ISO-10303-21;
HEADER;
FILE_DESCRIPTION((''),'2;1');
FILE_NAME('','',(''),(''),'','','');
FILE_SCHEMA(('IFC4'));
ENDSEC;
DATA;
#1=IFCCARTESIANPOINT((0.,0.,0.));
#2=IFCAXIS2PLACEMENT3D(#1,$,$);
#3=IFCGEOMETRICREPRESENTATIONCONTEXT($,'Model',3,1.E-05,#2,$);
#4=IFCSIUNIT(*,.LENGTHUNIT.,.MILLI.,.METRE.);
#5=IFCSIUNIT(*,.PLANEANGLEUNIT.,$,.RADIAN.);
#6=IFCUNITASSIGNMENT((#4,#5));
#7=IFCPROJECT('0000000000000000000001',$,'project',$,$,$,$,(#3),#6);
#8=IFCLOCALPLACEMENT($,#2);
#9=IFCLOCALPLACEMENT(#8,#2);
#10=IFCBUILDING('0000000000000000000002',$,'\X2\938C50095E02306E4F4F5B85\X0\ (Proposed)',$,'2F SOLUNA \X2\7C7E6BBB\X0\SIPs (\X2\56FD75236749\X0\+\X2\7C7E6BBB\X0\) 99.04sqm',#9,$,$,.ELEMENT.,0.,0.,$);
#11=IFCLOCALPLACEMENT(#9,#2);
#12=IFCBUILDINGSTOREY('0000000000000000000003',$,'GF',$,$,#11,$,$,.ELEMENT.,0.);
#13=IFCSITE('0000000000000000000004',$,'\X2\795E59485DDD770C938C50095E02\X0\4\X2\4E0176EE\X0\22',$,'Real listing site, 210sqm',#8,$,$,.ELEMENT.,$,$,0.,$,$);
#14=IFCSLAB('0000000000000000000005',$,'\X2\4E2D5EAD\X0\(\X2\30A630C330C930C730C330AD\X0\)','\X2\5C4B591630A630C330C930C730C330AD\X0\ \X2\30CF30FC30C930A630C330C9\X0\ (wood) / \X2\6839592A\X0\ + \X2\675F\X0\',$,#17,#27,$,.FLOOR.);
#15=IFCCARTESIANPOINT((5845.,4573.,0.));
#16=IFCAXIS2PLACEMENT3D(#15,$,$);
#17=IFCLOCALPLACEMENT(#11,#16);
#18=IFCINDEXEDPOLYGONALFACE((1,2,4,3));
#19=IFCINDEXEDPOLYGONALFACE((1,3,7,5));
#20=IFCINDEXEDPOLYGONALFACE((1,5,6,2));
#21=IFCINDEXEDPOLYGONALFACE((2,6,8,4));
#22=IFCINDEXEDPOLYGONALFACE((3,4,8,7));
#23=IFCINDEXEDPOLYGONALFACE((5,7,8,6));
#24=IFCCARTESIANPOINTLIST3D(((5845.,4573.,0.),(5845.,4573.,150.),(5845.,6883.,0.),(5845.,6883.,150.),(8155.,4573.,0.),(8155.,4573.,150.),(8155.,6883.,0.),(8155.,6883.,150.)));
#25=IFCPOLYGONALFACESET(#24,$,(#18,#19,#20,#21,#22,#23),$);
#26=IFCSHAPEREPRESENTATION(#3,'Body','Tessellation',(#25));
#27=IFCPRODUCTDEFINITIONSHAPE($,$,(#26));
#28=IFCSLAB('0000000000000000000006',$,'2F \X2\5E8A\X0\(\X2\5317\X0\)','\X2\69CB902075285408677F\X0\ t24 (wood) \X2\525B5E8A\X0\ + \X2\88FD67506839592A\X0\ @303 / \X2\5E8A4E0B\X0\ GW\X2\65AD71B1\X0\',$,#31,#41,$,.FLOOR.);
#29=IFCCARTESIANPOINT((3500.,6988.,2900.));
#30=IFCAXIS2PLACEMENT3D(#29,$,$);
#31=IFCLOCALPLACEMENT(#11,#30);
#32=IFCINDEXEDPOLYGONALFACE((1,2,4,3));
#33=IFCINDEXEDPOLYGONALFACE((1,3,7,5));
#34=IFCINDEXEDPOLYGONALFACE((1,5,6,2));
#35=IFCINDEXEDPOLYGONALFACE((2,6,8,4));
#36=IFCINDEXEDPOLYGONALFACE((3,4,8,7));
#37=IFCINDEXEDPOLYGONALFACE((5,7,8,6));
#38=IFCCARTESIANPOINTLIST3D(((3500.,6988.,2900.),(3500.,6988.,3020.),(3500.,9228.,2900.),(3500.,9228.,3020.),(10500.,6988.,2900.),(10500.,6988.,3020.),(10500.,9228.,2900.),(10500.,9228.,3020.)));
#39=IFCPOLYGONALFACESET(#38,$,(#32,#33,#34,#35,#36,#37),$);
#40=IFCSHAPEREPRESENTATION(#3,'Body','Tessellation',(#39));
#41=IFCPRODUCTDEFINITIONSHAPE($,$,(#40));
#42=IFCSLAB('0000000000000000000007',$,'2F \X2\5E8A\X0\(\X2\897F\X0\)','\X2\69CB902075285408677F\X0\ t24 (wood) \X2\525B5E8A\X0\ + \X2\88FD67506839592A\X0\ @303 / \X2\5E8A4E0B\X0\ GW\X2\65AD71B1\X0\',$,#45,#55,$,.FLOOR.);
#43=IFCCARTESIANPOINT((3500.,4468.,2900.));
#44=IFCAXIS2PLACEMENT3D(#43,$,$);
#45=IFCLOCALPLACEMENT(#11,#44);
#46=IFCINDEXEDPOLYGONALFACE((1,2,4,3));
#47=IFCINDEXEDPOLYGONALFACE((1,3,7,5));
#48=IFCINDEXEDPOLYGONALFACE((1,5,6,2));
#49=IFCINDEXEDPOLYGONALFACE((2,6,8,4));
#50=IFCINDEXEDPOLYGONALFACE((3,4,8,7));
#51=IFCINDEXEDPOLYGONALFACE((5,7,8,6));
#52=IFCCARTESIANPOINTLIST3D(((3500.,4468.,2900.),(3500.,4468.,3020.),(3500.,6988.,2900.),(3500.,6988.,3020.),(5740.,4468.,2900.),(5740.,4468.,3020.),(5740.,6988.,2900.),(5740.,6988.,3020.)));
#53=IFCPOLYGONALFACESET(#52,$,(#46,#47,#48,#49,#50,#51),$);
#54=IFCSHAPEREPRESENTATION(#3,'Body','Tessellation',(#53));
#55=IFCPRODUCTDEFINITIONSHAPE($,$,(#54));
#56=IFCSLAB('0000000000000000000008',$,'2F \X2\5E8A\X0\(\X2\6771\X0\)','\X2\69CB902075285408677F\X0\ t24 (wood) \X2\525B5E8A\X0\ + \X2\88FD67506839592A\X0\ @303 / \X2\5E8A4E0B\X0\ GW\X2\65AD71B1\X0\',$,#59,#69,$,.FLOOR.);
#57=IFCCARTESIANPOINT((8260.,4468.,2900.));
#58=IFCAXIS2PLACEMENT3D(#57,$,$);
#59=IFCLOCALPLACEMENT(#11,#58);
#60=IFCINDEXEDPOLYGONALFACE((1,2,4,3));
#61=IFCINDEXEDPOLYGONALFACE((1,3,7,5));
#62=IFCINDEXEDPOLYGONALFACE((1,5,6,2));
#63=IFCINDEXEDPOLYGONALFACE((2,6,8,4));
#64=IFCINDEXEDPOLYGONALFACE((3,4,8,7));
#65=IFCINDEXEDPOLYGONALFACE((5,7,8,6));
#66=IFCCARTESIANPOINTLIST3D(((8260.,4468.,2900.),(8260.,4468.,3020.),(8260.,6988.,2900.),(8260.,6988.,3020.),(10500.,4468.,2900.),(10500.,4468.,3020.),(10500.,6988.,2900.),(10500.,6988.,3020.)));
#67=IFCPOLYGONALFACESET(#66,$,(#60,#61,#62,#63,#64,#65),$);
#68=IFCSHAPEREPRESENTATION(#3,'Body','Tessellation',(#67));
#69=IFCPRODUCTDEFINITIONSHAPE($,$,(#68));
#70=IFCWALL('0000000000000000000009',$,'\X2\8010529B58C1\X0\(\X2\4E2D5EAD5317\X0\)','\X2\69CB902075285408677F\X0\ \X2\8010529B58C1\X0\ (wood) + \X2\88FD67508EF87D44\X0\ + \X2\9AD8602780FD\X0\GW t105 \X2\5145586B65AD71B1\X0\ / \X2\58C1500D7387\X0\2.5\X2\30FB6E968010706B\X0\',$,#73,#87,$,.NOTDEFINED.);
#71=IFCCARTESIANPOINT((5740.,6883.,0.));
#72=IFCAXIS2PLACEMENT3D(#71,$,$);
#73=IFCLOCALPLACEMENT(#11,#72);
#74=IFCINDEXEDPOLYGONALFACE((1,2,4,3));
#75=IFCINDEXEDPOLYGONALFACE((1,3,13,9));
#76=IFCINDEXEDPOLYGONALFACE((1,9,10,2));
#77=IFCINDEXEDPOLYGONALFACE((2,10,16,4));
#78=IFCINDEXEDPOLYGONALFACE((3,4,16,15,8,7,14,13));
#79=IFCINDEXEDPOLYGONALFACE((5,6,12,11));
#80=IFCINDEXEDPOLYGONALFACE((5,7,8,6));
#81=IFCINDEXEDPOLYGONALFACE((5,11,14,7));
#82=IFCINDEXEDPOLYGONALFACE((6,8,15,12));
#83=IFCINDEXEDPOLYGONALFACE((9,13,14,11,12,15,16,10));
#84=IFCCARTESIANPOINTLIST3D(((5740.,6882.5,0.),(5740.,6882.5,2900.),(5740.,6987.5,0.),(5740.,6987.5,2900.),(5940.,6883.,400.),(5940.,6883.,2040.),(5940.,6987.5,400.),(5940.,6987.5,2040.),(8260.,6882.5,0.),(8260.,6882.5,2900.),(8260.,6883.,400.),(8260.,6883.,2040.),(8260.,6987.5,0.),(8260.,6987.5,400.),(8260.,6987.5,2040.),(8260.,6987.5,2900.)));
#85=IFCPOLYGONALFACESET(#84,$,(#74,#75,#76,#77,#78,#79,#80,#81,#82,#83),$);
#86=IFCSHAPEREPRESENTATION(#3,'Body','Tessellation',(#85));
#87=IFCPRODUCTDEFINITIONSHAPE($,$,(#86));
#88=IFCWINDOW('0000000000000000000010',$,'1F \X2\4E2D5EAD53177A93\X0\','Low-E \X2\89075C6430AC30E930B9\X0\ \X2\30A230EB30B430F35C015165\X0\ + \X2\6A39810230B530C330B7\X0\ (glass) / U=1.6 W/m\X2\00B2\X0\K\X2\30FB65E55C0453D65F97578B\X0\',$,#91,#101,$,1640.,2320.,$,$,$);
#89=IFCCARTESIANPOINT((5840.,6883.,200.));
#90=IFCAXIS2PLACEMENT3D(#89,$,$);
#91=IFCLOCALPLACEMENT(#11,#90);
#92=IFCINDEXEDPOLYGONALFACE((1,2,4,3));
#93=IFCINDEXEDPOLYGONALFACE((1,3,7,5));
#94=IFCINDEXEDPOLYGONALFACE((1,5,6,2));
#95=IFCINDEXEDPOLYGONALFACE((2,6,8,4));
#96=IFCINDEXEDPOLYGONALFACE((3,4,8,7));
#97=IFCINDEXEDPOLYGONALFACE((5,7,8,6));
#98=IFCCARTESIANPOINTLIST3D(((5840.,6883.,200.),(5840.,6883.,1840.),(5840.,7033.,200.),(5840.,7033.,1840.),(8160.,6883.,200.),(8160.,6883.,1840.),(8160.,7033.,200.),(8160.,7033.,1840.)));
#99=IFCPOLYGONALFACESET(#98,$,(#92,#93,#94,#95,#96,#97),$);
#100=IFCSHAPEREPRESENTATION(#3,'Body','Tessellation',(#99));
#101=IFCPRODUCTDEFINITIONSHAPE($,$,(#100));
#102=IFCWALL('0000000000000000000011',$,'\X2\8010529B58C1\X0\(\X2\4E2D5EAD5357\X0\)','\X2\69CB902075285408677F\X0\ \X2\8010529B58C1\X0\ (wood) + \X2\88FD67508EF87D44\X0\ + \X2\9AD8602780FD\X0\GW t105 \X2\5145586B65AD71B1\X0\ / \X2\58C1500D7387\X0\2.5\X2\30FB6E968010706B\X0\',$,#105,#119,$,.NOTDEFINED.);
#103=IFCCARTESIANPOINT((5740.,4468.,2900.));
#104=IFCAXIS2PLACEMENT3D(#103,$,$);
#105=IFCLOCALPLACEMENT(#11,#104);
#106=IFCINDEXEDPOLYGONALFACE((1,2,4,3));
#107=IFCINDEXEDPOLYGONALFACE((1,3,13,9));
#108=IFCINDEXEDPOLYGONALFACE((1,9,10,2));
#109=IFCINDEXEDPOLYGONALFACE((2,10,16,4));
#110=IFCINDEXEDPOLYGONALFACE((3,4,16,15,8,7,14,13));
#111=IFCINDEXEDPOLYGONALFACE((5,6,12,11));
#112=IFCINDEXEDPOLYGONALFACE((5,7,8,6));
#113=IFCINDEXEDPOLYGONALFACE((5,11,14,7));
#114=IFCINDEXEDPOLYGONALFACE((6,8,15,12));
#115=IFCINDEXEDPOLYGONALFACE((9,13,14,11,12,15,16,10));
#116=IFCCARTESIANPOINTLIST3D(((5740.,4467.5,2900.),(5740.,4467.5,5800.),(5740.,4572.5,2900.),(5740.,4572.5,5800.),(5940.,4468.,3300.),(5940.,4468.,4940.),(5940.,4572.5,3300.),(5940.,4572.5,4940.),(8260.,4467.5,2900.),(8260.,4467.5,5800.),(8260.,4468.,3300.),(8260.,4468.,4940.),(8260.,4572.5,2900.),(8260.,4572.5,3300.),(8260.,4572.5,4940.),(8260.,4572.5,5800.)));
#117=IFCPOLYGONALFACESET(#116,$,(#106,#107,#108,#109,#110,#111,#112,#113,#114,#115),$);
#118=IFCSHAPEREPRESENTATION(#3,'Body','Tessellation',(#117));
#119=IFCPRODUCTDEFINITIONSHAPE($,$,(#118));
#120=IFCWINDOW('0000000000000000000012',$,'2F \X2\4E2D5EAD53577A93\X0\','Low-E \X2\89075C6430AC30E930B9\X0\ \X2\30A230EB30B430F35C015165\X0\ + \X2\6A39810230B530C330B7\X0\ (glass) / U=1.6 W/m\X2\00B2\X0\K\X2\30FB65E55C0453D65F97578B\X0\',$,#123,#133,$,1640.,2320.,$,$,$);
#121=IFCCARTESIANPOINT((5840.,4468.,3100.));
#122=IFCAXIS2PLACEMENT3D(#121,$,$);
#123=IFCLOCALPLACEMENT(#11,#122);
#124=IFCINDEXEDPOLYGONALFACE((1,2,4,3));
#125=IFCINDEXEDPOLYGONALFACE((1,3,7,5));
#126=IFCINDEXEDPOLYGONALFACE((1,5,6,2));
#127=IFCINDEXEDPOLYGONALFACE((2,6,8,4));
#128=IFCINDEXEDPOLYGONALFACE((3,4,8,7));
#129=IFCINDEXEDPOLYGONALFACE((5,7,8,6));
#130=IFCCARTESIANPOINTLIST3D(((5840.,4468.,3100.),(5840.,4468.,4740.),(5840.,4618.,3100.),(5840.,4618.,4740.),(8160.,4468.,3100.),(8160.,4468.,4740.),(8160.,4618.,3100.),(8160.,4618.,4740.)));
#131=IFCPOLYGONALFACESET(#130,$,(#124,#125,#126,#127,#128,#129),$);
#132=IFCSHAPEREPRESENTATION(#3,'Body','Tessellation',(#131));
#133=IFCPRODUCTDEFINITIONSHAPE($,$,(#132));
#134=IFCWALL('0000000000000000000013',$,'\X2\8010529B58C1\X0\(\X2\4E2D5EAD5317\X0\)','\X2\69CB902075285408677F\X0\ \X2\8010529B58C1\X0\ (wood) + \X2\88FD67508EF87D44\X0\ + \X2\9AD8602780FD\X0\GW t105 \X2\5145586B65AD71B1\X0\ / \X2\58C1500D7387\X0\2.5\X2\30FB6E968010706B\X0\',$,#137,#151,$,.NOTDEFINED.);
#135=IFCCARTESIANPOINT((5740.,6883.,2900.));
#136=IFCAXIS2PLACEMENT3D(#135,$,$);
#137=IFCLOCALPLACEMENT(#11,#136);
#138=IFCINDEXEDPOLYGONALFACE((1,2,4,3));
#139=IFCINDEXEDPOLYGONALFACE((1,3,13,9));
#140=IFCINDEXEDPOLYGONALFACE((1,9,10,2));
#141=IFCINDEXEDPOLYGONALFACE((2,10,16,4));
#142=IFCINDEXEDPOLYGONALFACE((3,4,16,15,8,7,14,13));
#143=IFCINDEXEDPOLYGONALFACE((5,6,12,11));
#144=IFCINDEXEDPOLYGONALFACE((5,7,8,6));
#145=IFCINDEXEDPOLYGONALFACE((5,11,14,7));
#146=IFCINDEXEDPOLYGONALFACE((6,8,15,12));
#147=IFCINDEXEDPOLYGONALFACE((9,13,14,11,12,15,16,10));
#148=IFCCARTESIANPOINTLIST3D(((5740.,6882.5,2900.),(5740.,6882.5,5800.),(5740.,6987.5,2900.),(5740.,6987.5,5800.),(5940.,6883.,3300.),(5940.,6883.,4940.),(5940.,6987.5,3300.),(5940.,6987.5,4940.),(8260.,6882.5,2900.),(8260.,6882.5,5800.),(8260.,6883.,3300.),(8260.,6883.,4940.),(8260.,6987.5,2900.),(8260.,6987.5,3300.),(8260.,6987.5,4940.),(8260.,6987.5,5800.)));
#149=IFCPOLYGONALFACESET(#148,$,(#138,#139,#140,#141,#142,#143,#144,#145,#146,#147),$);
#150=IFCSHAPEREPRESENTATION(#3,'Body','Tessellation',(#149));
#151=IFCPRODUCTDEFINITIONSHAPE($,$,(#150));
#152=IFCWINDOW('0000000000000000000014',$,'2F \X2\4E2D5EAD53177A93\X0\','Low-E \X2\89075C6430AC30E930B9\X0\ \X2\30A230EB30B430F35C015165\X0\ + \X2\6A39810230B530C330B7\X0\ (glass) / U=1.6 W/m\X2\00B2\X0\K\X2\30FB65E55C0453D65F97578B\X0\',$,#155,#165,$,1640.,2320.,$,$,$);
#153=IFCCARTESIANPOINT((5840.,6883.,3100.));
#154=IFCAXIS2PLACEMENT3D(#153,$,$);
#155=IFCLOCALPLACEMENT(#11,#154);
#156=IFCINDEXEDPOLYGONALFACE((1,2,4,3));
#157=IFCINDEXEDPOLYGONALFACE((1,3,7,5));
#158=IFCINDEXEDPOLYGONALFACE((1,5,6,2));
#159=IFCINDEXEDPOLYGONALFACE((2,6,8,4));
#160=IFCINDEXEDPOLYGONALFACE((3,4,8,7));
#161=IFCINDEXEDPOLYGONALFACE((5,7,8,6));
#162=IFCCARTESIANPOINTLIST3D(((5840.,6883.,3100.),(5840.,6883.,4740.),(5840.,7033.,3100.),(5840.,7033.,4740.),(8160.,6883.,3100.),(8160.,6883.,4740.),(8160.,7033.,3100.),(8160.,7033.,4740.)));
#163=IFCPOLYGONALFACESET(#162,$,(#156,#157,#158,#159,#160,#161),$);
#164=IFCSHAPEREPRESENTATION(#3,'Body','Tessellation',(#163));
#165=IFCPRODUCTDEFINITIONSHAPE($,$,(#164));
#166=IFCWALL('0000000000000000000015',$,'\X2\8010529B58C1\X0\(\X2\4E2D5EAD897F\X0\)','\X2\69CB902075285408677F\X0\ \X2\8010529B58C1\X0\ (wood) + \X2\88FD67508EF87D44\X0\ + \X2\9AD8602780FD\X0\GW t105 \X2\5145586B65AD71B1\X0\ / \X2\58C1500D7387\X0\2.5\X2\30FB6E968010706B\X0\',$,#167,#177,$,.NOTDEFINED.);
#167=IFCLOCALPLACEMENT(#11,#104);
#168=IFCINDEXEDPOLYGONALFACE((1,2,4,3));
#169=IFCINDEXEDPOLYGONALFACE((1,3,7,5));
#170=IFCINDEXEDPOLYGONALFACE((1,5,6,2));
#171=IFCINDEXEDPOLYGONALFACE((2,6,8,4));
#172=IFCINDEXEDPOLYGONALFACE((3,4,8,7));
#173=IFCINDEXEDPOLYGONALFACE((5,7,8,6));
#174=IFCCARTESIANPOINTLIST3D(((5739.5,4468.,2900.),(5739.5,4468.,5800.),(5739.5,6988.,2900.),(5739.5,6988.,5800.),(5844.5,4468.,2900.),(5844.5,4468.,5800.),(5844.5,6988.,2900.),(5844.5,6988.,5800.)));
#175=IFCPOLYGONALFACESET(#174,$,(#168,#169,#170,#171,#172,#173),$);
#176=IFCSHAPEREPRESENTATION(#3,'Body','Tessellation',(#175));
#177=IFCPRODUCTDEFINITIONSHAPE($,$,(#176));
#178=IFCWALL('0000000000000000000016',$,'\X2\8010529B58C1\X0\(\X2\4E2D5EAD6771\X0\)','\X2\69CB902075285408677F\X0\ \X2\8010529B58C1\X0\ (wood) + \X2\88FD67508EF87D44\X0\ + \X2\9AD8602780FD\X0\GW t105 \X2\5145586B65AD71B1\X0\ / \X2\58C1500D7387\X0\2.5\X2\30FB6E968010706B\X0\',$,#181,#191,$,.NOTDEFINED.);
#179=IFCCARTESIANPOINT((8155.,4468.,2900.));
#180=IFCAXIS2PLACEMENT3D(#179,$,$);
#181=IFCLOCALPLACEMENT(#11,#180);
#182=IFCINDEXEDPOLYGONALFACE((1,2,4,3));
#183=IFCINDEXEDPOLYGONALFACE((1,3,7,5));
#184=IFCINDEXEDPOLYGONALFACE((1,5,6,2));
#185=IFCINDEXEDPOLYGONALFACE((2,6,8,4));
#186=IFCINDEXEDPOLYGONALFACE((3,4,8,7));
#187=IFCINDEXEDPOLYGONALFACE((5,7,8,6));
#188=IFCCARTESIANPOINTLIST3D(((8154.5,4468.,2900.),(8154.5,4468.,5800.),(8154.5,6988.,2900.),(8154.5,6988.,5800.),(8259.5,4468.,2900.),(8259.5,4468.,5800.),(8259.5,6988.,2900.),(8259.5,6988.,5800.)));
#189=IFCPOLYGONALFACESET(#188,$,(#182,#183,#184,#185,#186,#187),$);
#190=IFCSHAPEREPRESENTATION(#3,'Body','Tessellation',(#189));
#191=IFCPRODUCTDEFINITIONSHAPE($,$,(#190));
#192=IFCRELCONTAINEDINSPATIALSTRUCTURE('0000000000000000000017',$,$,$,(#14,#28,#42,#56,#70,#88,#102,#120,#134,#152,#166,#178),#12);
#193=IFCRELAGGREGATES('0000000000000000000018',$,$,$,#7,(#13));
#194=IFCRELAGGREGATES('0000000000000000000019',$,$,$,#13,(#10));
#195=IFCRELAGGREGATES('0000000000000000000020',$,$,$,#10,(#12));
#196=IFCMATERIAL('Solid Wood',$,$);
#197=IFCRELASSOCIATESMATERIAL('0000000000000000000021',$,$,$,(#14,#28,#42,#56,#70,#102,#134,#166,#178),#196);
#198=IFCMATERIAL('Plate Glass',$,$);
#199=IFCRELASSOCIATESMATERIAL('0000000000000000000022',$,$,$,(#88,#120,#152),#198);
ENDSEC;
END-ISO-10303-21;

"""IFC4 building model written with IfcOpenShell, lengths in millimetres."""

from ifc_helpers import new_model, si_unit, frame, frame_2d, origin, place, context, project, spatial, rectangle, extrude, material, element, fill, save


model = new_model("IFC4")

# Units and contexts
model_context = context("Model", 3, precision=1e-05, world=origin())
ifc_project = project(units=[si_unit("LENGTHUNIT", "METRE", prefix="MILLI"), si_unit("PLANEANGLEUNIT", "RADIAN")], contexts=[model_context])

# Site, building, storey
site_placement = place(None, origin())
site = spatial("IfcSite", under=ifc_project, at=site_placement, Name="神奈川県鎌倉市4丁目22", ObjectType="Real listing site, 210sqm", CompositionType="ELEMENT", RefElevation=0.0)
building_placement = place(site_placement, origin())
building = spatial("IfcBuilding", under=site, at=building_placement, Name="鎌倉市の住宅 (Proposed)", ObjectType="2F SOLUNA 籾殻SIPs (国産杉+籾殻) 99.04sqm", CompositionType="ELEMENT", ElevationOfRefHeight=0.0, ElevationOfTerrain=0.0)
storey_placement = place(building_placement, origin())
storey = spatial("IfcBuildingStorey", under=building, at=storey_placement, Name="GF", CompositionType="ELEMENT", Elevation=0.0)

# Slabs
ifc_material_1 = material(Name="Solid Wood")
slab_1_placement = place(storey_placement, frame((5845.0, 4573.0, 0.0)))
element("IfcSlab", 1, at=slab_1_placement, inside=storey, material=ifc_material_1, Name="中庭(ウッドデッキ)", Description="屋外ウッドデッキ ハードウッド (wood) / 根太 + 束", PredefinedType="FLOOR", context=model_context, shape_type="SweptSolid", body=[
    extrude(rectangle(XDim=2310.0, YDim=2310.0, at=frame_2d((1155.0, 1155.0))), frame((5845.0, 4573.0, 0.0)), (0.0, 0.0, 1.0), 150.0),
])
slab_2_placement = place(storey_placement, frame((3500.0, 6988.0, 2900.0)))
element("IfcSlab", 2, at=slab_2_placement, inside=storey, material=ifc_material_1, Name="2F 床(北)", Description="構造用合板 t24 (wood) 剛床 + 製材根太 @303 / 床下 GW断熱", PredefinedType="FLOOR", context=model_context, shape_type="SweptSolid", body=[
    extrude(rectangle(XDim=7000.0, YDim=2240.0, at=frame_2d((3500.0, 1120.0))), frame((3500.0, 6988.0, 2900.0)), (0.0, 0.0, 1.0), 120.0),
])
slab_3_placement = place(storey_placement, frame((3500.0, 4468.0, 2900.0)))
element("IfcSlab", 3, at=slab_3_placement, inside=storey, material=ifc_material_1, Name="2F 床(西)", Description="構造用合板 t24 (wood) 剛床 + 製材根太 @303 / 床下 GW断熱", PredefinedType="FLOOR", context=model_context, shape_type="SweptSolid", body=[
    extrude(rectangle(XDim=2240.0, YDim=2520.0, at=frame_2d((1120.0, 1260.0))), frame((3500.0, 4468.0, 2900.0)), (0.0, 0.0, 1.0), 120.0),
])
slab_4_placement = place(storey_placement, frame((8260.0, 4468.0, 2900.0)))
element("IfcSlab", 4, at=slab_4_placement, inside=storey, material=ifc_material_1, Name="2F 床(東)", Description="構造用合板 t24 (wood) 剛床 + 製材根太 @303 / 床下 GW断熱", PredefinedType="FLOOR", context=model_context, shape_type="SweptSolid", body=[
    extrude(rectangle(XDim=2240.0, YDim=2520.0, at=frame_2d((1120.0, 1260.0))), frame((8260.0, 4468.0, 2900.0)), (0.0, 0.0, 1.0), 120.0),
])

# Wall, opening, window
wall_1_placement = place(storey_placement, frame((5740.0, 6883.0, 0.0)))
wall_1 = element("IfcWall", 5, at=wall_1_placement, inside=storey, material=ifc_material_1, Name="耐力壁(中庭北)", Description="構造用合板 耐力壁 (wood) + 製材軸組 + 高性能GW t105 充填断熱 / 壁倍率2.5・準耐火", PredefinedType="NOTDEFINED", context=model_context, shape_type="SweptSolid", body=[
    extrude(rectangle(XDim=2520.0, YDim=105.0, at=frame_2d((1260.0, 52.0))), frame((5740.0, 6883.0, 0.0)), (0.0, 0.0, 1.0), 2900.0),
])
opening_1_placement = place(storey_placement, frame((5840.0, 6883.0, 200.0)))
opening_1 = element("IfcOpeningElement", 6, at=opening_1_placement, cuts=wall_1, PredefinedType="NOTDEFINED", context=model_context, shape_type="SweptSolid", body=[
    extrude(rectangle(XDim=2320.0, YDim=150.0, at=frame_2d((1160.0, 75.0))), frame((5840.0, 6883.0, 200.0)), (0.0, 0.0, 1.0), 1640.0),
])
ifc_material_2 = material(Name="Plate Glass")
window_1_placement = place(storey_placement, frame((5840.0, 6883.0, 200.0)))
window_1 = element("IfcWindow", 7, at=window_1_placement, inside=storey, material=ifc_material_2, Name="1F 中庭北窓", Description="Low-E 複層ガラス アルゴン封入 + 樹脂サッシ (glass) / U=1.6 W/m²K・日射取得型", OverallHeight=1640.0, OverallWidth=2320.0, context=model_context, shape_type="SweptSolid", body=[
    extrude(rectangle(XDim=2320.0, YDim=150.0, at=frame_2d((1160.0, 75.0))), frame((5840.0, 6883.0, 200.0)), (0.0, 0.0, 1.0), 1640.0),
])
fill(opening_1, window_1)

# Walls, openings, windows
wall_2_placement = place(storey_placement, frame((5740.0, 4468.0, 2900.0)))
wall_2 = element("IfcWall", 8, at=wall_2_placement, inside=storey, material=ifc_material_1, Name="耐力壁(中庭南)", Description="構造用合板 耐力壁 (wood) + 製材軸組 + 高性能GW t105 充填断熱 / 壁倍率2.5・準耐火", PredefinedType="NOTDEFINED", context=model_context, shape_type="SweptSolid", body=[
    extrude(rectangle(XDim=2520.0, YDim=105.0, at=frame_2d((1260.0, 52.0))), frame((5740.0, 4468.0, 2900.0)), (0.0, 0.0, 1.0), 2900.0),
])
opening_2_placement = place(storey_placement, frame((5840.0, 4468.0, 3100.0)))
opening_2 = element("IfcOpeningElement", 9, at=opening_2_placement, cuts=wall_2, PredefinedType="NOTDEFINED", context=model_context, shape_type="SweptSolid", body=[
    extrude(rectangle(XDim=2320.0, YDim=150.0, at=frame_2d((1160.0, 75.0))), frame((5840.0, 4468.0, 3100.0)), (0.0, 0.0, 1.0), 1640.0),
])
window_2_placement = place(storey_placement, frame((5840.0, 4468.0, 3100.0)))
window_2 = element("IfcWindow", 10, at=window_2_placement, inside=storey, material=ifc_material_2, Name="2F 中庭南窓", Description="Low-E 複層ガラス アルゴン封入 + 樹脂サッシ (glass) / U=1.6 W/m²K・日射取得型", OverallHeight=1640.0, OverallWidth=2320.0, context=model_context, shape_type="SweptSolid", body=[
    extrude(rectangle(XDim=2320.0, YDim=150.0, at=frame_2d((1160.0, 75.0))), frame((5840.0, 4468.0, 3100.0)), (0.0, 0.0, 1.0), 1640.0),
])
fill(opening_2, window_2)
wall_3_placement = place(storey_placement, frame((5740.0, 6883.0, 2900.0)))
wall_3 = element("IfcWall", 11, at=wall_3_placement, inside=storey, material=ifc_material_1, Name="耐力壁(中庭北)", Description="構造用合板 耐力壁 (wood) + 製材軸組 + 高性能GW t105 充填断熱 / 壁倍率2.5・準耐火", PredefinedType="NOTDEFINED", context=model_context, shape_type="SweptSolid", body=[
    extrude(rectangle(XDim=2520.0, YDim=105.0, at=frame_2d((1260.0, 52.0))), frame((5740.0, 6883.0, 2900.0)), (0.0, 0.0, 1.0), 2900.0),
])
opening_3_placement = place(storey_placement, frame((5840.0, 6883.0, 3100.0)))
opening_3 = element("IfcOpeningElement", 12, at=opening_3_placement, cuts=wall_3, PredefinedType="NOTDEFINED", context=model_context, shape_type="SweptSolid", body=[
    extrude(rectangle(XDim=2320.0, YDim=150.0, at=frame_2d((1160.0, 75.0))), frame((5840.0, 6883.0, 3100.0)), (0.0, 0.0, 1.0), 1640.0),
])
window_3_placement = place(storey_placement, frame((5840.0, 6883.0, 3100.0)))
window_3 = element("IfcWindow", 13, at=window_3_placement, inside=storey, material=ifc_material_2, Name="2F 中庭北窓", Description="Low-E 複層ガラス アルゴン封入 + 樹脂サッシ (glass) / U=1.6 W/m²K・日射取得型", OverallHeight=1640.0, OverallWidth=2320.0, context=model_context, shape_type="SweptSolid", body=[
    extrude(rectangle(XDim=2320.0, YDim=150.0, at=frame_2d((1160.0, 75.0))), frame((5840.0, 6883.0, 3100.0)), (0.0, 0.0, 1.0), 1640.0),
])
fill(opening_3, window_3)

# Walls
wall_4_placement = place(storey_placement, frame((5740.0, 4468.0, 2900.0)))
element("IfcWall", 14, at=wall_4_placement, inside=storey, material=ifc_material_1, Name="耐力壁(中庭西)", Description="構造用合板 耐力壁 (wood) + 製材軸組 + 高性能GW t105 充填断熱 / 壁倍率2.5・準耐火", PredefinedType="NOTDEFINED", context=model_context, shape_type="SweptSolid", body=[
    extrude(rectangle(XDim=105.0, YDim=2520.0, at=frame_2d((52.0, 1260.0))), frame((5740.0, 4468.0, 2900.0)), (0.0, 0.0, 1.0), 2900.0),
])
wall_5_placement = place(storey_placement, frame((8155.0, 4468.0, 2900.0)))
element("IfcWall", 15, at=wall_5_placement, inside=storey, material=ifc_material_1, Name="耐力壁(中庭東)", Description="構造用合板 耐力壁 (wood) + 製材軸組 + 高性能GW t105 充填断熱 / 壁倍率2.5・準耐火", PredefinedType="NOTDEFINED", context=model_context, shape_type="SweptSolid", body=[
    extrude(rectangle(XDim=105.0, YDim=2520.0, at=frame_2d((52.0, 1260.0))), frame((8155.0, 4468.0, 2900.0)), (0.0, 0.0, 1.0), 2900.0),
])

save(model, "model.ifc")
